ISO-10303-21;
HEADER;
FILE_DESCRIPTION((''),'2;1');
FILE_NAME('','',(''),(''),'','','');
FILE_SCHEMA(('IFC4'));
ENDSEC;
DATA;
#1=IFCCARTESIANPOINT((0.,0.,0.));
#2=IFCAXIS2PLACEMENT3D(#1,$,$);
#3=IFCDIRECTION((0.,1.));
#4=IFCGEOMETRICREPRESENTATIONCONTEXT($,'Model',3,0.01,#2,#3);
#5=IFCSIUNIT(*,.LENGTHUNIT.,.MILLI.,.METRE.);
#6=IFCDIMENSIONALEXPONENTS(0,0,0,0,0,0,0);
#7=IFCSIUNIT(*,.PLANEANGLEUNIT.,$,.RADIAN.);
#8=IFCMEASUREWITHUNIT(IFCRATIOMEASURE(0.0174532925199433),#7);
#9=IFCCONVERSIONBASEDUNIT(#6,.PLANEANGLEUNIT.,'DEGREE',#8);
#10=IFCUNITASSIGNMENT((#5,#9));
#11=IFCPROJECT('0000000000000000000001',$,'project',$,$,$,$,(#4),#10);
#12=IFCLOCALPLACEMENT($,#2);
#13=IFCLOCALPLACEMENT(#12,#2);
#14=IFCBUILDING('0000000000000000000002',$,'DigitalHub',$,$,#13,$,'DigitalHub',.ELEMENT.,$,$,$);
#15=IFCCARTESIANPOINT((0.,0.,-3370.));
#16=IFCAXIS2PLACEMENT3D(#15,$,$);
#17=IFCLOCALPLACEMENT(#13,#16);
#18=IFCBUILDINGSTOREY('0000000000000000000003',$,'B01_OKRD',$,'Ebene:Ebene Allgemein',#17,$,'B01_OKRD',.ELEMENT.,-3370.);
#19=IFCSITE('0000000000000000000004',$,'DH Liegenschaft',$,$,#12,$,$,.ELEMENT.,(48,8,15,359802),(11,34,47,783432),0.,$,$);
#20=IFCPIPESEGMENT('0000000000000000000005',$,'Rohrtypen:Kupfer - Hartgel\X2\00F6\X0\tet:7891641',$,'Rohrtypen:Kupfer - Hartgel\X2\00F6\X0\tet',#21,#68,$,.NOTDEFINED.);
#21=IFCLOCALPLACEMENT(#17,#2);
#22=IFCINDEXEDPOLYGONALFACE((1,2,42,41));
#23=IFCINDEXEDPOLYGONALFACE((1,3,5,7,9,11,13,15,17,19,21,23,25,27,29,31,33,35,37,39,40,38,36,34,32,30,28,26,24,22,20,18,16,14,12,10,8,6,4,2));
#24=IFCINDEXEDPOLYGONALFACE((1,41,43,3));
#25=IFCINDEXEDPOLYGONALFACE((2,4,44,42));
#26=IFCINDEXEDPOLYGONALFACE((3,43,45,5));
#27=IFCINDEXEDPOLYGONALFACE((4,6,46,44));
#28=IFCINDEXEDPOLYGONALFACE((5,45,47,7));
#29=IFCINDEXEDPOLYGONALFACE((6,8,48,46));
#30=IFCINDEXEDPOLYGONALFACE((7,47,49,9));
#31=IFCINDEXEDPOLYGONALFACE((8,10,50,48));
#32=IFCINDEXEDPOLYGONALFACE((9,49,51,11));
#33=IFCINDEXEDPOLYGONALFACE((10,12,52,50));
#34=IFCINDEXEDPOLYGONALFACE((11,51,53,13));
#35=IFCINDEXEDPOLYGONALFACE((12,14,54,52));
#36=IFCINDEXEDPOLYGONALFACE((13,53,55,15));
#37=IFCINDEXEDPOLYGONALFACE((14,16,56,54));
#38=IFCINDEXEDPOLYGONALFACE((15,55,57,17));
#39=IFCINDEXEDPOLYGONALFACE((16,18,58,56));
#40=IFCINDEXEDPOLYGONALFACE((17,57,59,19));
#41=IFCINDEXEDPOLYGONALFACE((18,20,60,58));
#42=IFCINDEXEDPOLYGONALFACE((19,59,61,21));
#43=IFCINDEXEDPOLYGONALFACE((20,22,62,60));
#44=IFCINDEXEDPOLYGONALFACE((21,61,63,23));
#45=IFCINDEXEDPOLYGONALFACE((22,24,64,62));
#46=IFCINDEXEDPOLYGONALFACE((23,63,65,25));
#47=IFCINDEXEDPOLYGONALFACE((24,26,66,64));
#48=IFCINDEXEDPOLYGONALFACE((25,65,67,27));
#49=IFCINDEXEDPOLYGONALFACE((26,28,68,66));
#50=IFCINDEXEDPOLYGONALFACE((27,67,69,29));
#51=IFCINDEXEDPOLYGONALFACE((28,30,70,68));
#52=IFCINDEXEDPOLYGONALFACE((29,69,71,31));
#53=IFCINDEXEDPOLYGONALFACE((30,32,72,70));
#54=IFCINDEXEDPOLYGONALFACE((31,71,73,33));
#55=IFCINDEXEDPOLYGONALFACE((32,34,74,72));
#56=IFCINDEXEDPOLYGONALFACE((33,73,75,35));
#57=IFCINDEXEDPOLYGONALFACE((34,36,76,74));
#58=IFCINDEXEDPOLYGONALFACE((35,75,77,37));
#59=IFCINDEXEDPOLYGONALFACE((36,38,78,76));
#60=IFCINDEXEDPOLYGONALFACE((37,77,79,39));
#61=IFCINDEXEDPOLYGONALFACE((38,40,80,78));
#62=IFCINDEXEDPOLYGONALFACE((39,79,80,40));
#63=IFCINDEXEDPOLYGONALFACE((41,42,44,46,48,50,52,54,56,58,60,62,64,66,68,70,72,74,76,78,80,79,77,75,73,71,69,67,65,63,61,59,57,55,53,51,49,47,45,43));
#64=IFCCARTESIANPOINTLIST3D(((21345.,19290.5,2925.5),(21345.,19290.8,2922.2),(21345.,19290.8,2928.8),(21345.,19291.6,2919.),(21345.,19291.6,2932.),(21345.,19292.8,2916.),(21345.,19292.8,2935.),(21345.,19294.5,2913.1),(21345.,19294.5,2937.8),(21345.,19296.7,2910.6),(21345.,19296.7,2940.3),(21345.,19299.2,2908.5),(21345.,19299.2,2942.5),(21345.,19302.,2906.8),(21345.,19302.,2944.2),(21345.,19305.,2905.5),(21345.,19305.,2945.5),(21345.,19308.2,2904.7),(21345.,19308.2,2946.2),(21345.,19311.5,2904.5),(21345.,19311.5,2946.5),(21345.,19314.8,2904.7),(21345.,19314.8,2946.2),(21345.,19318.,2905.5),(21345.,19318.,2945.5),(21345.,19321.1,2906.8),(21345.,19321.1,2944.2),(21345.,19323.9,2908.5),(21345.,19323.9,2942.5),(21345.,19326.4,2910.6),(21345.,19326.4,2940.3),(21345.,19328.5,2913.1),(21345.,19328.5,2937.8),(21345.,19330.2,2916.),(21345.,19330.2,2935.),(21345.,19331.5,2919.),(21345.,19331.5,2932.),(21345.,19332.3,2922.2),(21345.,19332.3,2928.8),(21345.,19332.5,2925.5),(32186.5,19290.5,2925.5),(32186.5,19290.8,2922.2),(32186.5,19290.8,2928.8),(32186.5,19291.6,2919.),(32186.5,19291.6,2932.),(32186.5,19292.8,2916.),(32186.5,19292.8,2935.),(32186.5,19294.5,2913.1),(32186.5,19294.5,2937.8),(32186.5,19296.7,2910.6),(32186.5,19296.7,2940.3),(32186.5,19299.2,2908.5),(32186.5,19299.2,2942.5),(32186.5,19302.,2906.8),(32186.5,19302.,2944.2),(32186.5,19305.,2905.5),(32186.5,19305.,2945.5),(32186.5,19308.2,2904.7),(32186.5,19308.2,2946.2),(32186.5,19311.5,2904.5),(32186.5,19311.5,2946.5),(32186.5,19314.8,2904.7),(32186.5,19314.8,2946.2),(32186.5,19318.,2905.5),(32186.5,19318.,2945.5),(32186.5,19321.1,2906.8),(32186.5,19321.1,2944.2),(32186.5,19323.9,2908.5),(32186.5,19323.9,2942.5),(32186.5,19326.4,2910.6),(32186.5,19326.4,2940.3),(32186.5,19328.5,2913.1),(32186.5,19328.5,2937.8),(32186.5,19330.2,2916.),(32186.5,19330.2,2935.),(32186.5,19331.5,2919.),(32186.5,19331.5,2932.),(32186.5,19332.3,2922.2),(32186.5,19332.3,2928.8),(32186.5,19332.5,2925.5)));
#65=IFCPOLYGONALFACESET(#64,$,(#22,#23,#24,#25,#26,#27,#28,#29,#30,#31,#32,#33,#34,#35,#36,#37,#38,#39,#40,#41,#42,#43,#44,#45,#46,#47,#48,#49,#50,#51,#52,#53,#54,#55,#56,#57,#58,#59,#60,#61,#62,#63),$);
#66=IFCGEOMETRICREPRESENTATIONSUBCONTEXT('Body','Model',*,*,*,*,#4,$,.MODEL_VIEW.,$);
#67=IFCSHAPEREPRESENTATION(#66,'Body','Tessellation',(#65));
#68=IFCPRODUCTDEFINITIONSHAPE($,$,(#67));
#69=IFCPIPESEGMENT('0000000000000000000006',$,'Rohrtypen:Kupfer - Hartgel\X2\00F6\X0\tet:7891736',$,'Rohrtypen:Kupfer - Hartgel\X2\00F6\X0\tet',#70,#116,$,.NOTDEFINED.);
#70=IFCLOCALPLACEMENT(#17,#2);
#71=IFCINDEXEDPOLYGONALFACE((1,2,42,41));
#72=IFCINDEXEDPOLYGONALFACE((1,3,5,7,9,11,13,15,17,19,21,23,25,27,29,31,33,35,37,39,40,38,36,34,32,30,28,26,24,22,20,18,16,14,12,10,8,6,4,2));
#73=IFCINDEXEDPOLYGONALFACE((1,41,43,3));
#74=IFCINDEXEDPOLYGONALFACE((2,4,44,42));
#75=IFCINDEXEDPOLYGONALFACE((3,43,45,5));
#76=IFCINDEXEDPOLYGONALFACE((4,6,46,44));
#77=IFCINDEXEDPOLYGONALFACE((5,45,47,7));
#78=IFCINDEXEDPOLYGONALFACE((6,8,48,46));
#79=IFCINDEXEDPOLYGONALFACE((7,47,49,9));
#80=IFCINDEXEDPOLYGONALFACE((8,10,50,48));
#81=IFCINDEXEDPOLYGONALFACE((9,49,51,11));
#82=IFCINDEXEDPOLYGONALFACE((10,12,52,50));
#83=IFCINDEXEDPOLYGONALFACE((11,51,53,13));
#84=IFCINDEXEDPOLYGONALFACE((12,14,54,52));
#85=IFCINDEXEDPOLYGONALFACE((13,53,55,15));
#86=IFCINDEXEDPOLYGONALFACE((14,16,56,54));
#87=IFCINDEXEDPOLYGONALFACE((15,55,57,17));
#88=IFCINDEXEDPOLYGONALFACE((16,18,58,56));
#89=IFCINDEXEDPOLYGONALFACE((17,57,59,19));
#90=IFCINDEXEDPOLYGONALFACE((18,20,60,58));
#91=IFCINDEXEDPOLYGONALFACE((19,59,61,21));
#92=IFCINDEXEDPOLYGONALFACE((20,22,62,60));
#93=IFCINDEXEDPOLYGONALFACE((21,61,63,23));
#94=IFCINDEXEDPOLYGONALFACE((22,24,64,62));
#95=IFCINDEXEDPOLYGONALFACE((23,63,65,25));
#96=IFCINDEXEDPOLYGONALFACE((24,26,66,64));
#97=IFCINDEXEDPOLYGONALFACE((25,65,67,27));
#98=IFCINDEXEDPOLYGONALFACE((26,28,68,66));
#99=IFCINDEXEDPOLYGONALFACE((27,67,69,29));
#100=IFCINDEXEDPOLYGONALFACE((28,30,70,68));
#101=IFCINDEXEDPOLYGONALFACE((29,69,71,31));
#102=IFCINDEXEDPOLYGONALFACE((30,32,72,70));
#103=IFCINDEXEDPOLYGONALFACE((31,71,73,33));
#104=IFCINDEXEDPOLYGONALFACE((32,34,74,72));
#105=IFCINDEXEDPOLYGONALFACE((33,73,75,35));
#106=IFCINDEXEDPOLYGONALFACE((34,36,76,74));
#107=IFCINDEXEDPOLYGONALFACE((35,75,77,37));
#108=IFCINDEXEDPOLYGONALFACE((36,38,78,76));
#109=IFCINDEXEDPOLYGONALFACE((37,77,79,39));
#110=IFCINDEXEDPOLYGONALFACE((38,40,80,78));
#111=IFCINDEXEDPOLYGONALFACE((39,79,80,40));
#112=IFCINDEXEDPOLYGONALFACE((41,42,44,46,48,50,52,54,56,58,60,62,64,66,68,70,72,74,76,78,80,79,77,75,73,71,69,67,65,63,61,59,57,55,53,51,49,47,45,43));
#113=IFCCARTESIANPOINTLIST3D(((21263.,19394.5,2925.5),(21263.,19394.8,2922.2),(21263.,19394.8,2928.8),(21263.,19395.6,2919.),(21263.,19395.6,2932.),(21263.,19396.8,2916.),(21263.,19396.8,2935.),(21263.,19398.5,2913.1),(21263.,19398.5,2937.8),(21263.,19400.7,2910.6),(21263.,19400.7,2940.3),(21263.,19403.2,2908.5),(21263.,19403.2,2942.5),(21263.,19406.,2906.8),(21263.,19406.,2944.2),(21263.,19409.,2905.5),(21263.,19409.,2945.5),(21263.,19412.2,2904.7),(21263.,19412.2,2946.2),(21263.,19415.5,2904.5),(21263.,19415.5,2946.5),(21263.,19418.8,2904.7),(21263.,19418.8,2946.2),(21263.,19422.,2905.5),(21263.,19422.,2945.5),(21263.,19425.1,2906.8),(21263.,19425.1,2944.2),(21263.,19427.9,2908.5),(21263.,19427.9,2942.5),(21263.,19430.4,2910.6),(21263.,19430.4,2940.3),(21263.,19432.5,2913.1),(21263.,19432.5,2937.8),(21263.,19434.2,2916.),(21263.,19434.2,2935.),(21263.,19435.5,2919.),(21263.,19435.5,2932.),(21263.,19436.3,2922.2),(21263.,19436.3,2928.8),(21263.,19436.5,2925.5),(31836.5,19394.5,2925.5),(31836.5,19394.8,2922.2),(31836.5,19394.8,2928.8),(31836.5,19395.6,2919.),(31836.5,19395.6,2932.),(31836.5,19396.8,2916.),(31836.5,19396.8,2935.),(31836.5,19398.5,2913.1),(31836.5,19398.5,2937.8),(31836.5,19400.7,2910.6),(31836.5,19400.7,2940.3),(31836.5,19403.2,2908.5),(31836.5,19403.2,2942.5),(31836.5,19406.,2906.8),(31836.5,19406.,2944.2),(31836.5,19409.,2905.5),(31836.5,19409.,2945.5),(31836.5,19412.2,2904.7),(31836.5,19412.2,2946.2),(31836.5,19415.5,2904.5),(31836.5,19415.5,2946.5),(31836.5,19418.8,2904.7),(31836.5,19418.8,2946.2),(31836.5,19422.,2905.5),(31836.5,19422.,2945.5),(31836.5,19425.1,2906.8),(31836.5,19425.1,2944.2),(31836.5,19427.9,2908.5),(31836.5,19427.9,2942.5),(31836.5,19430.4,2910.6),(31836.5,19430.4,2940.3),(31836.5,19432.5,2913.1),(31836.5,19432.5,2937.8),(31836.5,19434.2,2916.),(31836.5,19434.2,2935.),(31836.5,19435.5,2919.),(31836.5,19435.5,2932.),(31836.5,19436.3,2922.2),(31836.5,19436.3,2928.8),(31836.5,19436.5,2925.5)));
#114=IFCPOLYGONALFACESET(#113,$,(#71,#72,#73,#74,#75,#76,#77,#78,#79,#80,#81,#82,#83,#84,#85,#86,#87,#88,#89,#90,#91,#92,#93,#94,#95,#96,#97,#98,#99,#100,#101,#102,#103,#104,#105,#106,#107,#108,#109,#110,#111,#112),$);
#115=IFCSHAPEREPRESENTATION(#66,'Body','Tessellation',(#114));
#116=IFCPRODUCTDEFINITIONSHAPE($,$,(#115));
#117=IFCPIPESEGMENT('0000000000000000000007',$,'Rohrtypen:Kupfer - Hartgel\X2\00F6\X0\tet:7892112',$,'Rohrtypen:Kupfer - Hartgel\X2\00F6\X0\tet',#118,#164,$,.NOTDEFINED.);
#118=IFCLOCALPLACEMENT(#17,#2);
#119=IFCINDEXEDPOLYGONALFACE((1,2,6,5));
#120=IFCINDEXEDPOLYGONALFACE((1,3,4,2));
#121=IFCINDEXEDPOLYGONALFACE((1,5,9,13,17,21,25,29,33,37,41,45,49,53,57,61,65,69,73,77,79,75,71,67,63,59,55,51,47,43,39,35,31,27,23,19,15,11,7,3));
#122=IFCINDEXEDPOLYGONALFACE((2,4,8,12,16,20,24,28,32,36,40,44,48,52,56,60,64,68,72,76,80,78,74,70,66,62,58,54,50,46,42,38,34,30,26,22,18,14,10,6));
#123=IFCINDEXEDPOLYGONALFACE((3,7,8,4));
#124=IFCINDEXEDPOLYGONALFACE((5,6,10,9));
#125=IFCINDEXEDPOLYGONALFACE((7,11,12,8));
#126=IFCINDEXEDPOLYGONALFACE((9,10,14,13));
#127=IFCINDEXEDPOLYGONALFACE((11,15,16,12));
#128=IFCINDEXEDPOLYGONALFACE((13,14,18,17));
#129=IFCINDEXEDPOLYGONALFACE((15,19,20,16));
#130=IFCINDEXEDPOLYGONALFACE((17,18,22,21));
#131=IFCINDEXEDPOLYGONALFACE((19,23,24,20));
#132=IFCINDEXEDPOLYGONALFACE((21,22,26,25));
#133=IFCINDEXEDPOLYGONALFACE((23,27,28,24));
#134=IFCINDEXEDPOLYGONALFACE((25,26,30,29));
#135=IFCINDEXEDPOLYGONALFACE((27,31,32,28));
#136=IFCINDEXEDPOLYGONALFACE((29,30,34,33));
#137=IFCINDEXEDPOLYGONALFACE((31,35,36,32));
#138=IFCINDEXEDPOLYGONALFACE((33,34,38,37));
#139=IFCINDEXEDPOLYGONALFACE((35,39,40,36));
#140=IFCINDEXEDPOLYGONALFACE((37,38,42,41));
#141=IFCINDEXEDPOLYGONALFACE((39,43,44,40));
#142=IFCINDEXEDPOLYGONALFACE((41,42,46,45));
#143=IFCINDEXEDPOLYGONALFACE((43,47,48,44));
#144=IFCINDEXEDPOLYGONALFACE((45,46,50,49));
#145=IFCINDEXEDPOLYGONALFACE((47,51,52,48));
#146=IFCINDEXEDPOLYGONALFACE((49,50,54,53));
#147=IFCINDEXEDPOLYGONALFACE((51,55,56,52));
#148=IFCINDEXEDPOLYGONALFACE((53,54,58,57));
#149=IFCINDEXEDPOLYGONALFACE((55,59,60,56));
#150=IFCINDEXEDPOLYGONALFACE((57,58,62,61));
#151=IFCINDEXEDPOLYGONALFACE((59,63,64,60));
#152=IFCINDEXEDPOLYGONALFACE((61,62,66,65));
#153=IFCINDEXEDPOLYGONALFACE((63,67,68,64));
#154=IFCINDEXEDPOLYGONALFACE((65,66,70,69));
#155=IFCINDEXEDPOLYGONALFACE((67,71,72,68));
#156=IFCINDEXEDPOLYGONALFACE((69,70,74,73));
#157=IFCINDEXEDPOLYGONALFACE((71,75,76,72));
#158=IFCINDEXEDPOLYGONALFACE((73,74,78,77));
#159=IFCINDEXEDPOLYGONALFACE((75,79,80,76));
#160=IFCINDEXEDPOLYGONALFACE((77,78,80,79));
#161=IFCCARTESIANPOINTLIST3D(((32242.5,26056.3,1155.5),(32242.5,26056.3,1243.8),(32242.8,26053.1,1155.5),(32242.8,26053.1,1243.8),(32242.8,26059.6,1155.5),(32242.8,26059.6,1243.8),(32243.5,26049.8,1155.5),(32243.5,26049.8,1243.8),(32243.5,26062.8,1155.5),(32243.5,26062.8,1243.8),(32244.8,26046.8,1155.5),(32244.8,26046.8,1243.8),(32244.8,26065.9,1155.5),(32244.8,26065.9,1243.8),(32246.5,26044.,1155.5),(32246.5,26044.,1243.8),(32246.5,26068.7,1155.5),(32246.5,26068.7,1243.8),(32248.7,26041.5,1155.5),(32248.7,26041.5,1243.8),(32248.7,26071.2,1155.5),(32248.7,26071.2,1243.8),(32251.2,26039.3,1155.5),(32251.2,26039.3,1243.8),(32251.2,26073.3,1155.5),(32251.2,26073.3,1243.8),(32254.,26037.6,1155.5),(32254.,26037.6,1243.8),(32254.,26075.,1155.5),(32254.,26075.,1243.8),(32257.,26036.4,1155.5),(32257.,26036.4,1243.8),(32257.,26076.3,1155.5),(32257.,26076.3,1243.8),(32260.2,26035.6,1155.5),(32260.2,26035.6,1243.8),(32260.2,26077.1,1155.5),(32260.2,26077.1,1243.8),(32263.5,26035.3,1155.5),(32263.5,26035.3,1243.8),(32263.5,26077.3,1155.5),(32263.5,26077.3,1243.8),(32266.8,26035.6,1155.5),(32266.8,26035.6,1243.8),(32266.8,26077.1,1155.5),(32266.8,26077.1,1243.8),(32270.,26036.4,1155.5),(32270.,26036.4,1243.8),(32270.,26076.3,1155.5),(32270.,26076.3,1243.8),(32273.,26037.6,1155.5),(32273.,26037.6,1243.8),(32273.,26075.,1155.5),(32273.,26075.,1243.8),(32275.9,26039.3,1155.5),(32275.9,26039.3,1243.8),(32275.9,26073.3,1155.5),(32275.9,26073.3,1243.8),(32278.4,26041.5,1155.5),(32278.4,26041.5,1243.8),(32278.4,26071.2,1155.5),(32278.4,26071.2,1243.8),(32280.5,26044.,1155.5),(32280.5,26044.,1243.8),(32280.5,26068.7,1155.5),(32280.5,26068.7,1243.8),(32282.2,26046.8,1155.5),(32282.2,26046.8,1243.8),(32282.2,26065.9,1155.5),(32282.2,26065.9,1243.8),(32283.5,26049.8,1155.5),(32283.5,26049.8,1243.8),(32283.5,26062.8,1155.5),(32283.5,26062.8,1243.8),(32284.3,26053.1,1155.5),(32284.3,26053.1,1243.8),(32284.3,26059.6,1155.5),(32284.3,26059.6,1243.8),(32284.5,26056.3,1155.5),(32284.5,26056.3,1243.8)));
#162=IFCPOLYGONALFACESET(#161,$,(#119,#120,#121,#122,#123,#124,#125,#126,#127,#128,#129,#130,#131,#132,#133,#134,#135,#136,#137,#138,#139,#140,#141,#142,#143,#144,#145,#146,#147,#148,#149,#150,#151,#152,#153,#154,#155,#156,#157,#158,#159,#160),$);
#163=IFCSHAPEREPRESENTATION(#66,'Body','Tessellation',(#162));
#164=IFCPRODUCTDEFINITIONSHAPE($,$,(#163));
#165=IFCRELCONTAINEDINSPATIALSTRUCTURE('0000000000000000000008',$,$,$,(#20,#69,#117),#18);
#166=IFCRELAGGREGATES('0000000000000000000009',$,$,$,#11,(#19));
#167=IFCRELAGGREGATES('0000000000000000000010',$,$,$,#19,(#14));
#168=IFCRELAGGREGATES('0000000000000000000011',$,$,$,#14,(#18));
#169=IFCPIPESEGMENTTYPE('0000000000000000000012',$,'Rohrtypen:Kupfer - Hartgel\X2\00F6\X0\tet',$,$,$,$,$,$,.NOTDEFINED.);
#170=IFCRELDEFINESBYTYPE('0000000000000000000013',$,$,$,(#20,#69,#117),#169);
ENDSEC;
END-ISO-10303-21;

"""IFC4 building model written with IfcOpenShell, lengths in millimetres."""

from ifc_helpers import new_model, entity, si_unit, converted_unit, direction, frame, origin, place, context, subcontext, project, spatial, indexed_curve, outline, extrude, type_object, element, save


model = new_model("IFC4")

# Units and contexts
model_context = context("Model", 3, precision=0.01, world=origin(), true_north=direction((0.0, 1.0)))
body_context = subcontext(model_context, "Body", "Model", "MODEL_VIEW")
ifc_project = project(units=[si_unit("LENGTHUNIT", "METRE", prefix="MILLI"), converted_unit("PLANEANGLEUNIT", "DEGREE", entity("IfcRatioMeasure", 0.0174532925199433), si_unit("PLANEANGLEUNIT", "RADIAN"), dimensions=[0, 0, 0, 0, 0, 0, 0])], contexts=[model_context])

# Site, building, storey
site_placement = place(None, origin())
site = spatial("IfcSite", under=ifc_project, at=site_placement, Name="DH Liegenschaft", CompositionType="ELEMENT", RefLatitude=(48, 8, 15, 359802), RefLongitude=(11, 34, 47, 783432), RefElevation=0.0)
building_placement = place(site_placement, origin())
building = spatial("IfcBuilding", under=site, at=building_placement, Name="DigitalHub", LongName="DigitalHub", CompositionType="ELEMENT")
storey_placement = place(building_placement, frame((0.0, 0.0, -3370.0)))
storey = spatial("IfcBuildingStorey", under=building, at=storey_placement, Name="B01_OKRD", ObjectType="Ebene:Ebene Allgemein", LongName="B01_OKRD", CompositionType="ELEMENT", Elevation=-3370.0)

# Pipe segments
pipe_segment_type = type_object("IfcPipeSegmentType", Name="Rohrtypen:Kupfer - Hartgelötet", PredefinedType="NOTDEFINED")
pipe_segment_1_placement = place(storey_placement, frame((21345.0, 19288.9, 2902.9)))
element("IfcPipeSegment", 1, at=pipe_segment_1_placement, inside=storey, type_object=pipe_segment_type, Name="Rohrtypen:Kupfer - Hartgelötet:7891641", ObjectType="Rohrtypen:Kupfer - Hartgelötet", PredefinedType="NOTDEFINED", context=body_context, shape_type="SweptSolid", body=[
    extrude(outline(indexed_curve([(21.0, 0.0), (20.7, 3.3), (20.0, 6.5), (18.7, 9.5), (17.0, 12.3), (14.8, 14.8), (12.3, 17.0), (9.5, 18.7), (6.5, 20.0), (3.3, 20.7), (0.0, 21.0), (-3.3, 20.7), (-6.5, 20.0), (-9.5, 18.7), (-12.3, 17.0), (-14.8, 14.8), (-17.0, 12.3), (-18.7, 9.5), (-20.0, 6.5), (-20.7, 3.3), (-21.0, 0.0), (-20.7, -3.3), (-20.0, -6.5), (-18.7, -9.5), (-17.0, -12.3), (-14.8, -14.8), (-12.3, -17.0), (-9.5, -18.7), (-6.5, -20.0), (-3.3, -20.7), (0.0, -21.0), (3.3, -20.7), (6.5, -20.0), (9.5, -18.7), (12.3, -17.0), (14.8, -14.8), (17.0, -12.3), (18.7, -9.5), (20.0, -6.5), (20.7, -3.3), (21.0, 0.0)], self_intersect=False)), frame((0.0, 22.6, 22.6), z_axis=(1.0, 0.0, 0.0), x_axis=(0.0, -1.0, 0.0)), (0.0, 0.0, 1.0), 10841.6),
])
pipe_segment_2_placement = place(storey_placement, frame((21263.0, 19392.9, 2902.9)))
element("IfcPipeSegment", 2, at=pipe_segment_2_placement, inside=storey, type_object=pipe_segment_type, Name="Rohrtypen:Kupfer - Hartgelötet:7891736", ObjectType="Rohrtypen:Kupfer - Hartgelötet", PredefinedType="NOTDEFINED", context=body_context, shape_type="SweptSolid", body=[
    extrude(outline(indexed_curve([(21.0, 0.0), (20.7, 3.3), (20.0, 6.5), (18.7, 9.5), (17.0, 12.3), (14.8, 14.8), (12.3, 17.0), (9.5, 18.7), (6.5, 20.0), (3.3, 20.7), (0.0, 21.0), (-3.3, 20.7), (-6.5, 20.0), (-9.5, 18.7), (-12.3, 17.0), (-14.8, 14.8), (-17.0, 12.3), (-18.7, 9.5), (-20.0, 6.5), (-20.7, 3.3), (-21.0, 0.0), (-20.7, -3.3), (-20.0, -6.5), (-18.7, -9.5), (-17.0, -12.3), (-14.8, -14.8), (-12.3, -17.0), (-9.5, -18.7), (-6.5, -20.0), (-3.3, -20.7), (0.0, -21.0), (3.3, -20.7), (6.5, -20.0), (9.5, -18.7), (12.3, -17.0), (14.8, -14.8), (17.0, -12.3), (18.7, -9.5), (20.0, -6.5), (20.7, -3.3), (21.0, 0.0)], self_intersect=False)), frame((0.0, 22.6, 22.6), z_axis=(1.0, 0.0, 0.0), x_axis=(0.0, -1.0, 0.0)), (0.0, 0.0, 1.0), 10573.6),
])
pipe_segment_3_placement = place(storey_placement, frame((32240.9, 26033.7, 1155.5)))
element("IfcPipeSegment", 3, at=pipe_segment_3_placement, inside=storey, type_object=pipe_segment_type, Name="Rohrtypen:Kupfer - Hartgelötet:7892112", ObjectType="Rohrtypen:Kupfer - Hartgelötet", PredefinedType="NOTDEFINED", context=body_context, shape_type="SweptSolid", body=[
    extrude(outline(indexed_curve([(21.0, 0.0), (20.7, 3.3), (20.0, 6.5), (18.7, 9.5), (17.0, 12.3), (14.8, 14.8), (12.3, 17.0), (9.5, 18.7), (6.5, 20.0), (3.3, 20.7), (0.0, 21.0), (-3.3, 20.7), (-6.5, 20.0), (-9.5, 18.7), (-12.3, 17.0), (-14.8, 14.8), (-17.0, 12.3), (-18.7, 9.5), (-20.0, 6.5), (-20.7, 3.3), (-21.0, 0.0), (-20.7, -3.3), (-20.0, -6.5), (-18.7, -9.5), (-17.0, -12.3), (-14.8, -14.8), (-12.3, -17.0), (-9.5, -18.7), (-6.5, -20.0), (-3.3, -20.7), (0.0, -21.0), (3.3, -20.7), (6.5, -20.0), (9.5, -18.7), (12.3, -17.0), (14.8, -14.8), (17.0, -12.3), (18.7, -9.5), (20.0, -6.5), (20.7, -3.3), (21.0, 0.0)], self_intersect=False)), frame((22.6, 22.6, 0.0), z_axis=(0.0, 0.0, 1.0), x_axis=(-1.0, 0.0, 0.0)), (0.0, 0.0, 1.0), 88.4),
])

save(model, "model.ifc")
